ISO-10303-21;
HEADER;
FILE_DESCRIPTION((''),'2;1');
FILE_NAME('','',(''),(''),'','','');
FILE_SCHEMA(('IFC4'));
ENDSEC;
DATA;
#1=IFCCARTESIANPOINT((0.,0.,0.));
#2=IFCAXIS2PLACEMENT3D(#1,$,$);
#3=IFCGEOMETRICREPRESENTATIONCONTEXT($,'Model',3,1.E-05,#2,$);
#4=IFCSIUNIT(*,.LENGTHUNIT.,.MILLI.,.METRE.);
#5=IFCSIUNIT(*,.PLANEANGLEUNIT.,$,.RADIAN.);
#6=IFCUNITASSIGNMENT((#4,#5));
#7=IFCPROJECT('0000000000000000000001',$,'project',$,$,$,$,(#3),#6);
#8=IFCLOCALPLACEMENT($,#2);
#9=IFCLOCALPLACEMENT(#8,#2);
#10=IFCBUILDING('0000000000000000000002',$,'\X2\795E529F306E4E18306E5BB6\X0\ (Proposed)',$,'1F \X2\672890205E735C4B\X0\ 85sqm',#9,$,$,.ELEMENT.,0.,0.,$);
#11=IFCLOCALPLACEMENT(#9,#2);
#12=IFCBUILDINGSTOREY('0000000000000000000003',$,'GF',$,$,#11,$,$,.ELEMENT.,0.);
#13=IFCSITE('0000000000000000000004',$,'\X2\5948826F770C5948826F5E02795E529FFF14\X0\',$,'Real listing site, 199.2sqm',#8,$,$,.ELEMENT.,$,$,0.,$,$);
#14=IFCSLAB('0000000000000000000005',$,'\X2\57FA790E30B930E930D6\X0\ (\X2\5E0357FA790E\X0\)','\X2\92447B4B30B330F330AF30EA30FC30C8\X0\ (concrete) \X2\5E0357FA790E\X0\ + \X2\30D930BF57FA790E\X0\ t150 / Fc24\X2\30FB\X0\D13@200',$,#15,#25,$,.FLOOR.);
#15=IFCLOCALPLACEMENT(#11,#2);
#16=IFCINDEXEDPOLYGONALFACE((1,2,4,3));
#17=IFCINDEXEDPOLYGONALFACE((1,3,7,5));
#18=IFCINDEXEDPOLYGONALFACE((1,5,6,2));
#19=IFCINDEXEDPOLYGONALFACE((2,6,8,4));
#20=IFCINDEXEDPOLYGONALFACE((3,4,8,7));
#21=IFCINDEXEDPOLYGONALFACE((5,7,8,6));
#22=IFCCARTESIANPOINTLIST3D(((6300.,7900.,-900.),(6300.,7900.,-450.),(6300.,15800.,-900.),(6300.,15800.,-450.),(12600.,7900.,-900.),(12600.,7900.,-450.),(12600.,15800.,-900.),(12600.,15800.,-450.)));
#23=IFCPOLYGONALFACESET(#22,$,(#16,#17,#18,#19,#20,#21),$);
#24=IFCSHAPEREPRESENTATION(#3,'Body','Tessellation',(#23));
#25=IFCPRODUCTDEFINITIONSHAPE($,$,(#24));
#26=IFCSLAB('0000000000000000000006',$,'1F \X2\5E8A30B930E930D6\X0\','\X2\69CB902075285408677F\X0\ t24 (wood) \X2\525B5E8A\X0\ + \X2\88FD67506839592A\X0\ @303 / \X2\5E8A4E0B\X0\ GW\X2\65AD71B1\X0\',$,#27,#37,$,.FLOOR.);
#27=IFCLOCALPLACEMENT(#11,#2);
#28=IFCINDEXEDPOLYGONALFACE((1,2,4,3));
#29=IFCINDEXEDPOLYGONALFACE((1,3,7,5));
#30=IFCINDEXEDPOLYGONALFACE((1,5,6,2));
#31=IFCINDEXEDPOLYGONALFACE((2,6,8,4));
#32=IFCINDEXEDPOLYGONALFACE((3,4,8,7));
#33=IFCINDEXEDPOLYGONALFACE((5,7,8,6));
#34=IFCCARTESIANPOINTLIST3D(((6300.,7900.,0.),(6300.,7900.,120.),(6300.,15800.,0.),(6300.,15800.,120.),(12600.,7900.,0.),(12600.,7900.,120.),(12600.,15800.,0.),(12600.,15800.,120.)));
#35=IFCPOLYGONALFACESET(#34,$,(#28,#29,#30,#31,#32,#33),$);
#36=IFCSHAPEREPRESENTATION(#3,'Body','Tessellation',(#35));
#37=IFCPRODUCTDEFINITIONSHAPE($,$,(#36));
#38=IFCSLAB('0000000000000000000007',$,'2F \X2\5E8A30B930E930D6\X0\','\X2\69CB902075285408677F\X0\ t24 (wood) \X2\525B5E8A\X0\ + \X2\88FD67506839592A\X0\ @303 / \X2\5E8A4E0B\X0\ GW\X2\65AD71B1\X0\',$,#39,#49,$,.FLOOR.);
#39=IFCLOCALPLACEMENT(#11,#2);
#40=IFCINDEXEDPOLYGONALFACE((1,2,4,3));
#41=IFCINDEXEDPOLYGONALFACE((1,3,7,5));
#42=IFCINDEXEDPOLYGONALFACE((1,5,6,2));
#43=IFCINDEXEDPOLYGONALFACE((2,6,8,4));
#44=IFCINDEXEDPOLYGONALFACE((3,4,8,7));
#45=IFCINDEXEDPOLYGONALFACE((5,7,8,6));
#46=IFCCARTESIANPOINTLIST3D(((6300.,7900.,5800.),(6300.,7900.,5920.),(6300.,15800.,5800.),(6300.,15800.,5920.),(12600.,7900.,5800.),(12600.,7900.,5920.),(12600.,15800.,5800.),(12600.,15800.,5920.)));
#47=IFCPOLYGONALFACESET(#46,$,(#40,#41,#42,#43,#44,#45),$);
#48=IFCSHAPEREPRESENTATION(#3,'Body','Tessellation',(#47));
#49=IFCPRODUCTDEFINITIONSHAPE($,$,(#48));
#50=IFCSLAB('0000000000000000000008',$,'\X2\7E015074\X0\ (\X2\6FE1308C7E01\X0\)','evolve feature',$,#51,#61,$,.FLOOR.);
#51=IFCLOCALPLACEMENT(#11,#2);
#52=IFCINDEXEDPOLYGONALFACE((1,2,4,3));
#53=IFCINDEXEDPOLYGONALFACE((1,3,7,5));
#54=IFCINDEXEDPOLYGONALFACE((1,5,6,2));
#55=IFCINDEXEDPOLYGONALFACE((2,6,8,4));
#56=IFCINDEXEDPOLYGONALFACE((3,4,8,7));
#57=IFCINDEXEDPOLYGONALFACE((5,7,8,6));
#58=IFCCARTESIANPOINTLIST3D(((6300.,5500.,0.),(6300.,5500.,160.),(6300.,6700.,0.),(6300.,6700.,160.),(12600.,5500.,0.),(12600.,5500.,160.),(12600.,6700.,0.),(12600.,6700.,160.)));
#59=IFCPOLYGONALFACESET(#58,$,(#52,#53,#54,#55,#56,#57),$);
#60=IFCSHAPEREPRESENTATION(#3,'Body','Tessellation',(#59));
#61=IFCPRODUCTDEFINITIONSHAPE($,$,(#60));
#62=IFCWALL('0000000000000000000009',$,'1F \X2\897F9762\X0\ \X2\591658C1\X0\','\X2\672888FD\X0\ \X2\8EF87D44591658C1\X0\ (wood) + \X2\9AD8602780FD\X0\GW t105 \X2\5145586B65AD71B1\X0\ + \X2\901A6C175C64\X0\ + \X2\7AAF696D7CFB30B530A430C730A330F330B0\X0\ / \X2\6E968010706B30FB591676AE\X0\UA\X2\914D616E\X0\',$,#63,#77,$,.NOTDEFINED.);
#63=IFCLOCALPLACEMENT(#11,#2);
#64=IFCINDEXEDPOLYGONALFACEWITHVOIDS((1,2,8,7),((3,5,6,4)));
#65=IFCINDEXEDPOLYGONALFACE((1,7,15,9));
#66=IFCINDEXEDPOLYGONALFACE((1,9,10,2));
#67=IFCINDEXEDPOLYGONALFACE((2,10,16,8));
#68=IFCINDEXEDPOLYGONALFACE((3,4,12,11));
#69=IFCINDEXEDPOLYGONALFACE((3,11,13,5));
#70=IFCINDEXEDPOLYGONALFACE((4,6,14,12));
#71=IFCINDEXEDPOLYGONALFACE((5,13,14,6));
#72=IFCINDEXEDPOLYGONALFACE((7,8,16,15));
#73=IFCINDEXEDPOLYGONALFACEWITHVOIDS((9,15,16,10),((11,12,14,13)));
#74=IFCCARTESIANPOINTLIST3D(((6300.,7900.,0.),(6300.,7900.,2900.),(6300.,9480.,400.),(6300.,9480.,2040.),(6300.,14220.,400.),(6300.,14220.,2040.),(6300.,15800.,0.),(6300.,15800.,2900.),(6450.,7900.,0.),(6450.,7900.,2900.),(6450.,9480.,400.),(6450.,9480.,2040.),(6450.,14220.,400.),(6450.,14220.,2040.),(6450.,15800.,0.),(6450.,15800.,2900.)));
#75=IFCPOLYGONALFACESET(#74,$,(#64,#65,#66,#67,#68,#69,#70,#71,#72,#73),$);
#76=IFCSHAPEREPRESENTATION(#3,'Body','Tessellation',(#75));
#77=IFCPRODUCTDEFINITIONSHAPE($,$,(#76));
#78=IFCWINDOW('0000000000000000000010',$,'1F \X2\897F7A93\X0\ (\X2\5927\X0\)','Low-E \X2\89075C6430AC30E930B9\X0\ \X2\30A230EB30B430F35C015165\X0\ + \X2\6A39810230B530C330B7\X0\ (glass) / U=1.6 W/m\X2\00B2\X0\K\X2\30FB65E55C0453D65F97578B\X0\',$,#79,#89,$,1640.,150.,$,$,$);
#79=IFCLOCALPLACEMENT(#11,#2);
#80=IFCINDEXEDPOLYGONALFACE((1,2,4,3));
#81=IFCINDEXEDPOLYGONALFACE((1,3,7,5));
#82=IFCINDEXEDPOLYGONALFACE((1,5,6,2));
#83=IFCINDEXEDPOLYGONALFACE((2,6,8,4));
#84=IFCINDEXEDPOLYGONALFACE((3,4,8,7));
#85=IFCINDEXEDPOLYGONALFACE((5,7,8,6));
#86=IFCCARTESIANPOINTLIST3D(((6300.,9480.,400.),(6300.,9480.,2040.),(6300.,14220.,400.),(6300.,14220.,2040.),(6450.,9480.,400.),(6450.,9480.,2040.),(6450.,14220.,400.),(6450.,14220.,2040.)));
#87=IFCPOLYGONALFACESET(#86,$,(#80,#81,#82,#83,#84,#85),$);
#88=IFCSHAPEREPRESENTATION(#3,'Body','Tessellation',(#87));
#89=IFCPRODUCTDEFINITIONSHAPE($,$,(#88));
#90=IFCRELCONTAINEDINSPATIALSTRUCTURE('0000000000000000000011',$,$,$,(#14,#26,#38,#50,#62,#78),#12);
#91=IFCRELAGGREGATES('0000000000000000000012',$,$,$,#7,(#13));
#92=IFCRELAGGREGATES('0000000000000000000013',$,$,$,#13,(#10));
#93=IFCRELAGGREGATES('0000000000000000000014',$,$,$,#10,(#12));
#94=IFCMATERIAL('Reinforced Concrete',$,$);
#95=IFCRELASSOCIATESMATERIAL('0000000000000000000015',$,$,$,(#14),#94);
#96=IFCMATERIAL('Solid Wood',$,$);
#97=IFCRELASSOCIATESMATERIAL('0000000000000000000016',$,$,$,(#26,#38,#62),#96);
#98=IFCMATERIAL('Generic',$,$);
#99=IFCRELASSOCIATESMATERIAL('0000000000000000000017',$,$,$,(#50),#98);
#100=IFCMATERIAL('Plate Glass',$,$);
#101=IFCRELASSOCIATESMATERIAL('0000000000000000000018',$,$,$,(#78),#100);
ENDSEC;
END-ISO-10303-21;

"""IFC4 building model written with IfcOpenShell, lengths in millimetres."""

from ifc_helpers import new_model, si_unit, frame, frame_2d, origin, place, context, project, spatial, rectangle, extrude, material, element, fill, save


model = new_model("IFC4")

# Units and contexts
model_context = context("Model", 3, precision=1e-05, world=origin())
ifc_project = project(units=[si_unit("LENGTHUNIT", "METRE", prefix="MILLI"), si_unit("PLANEANGLEUNIT", "RADIAN")], contexts=[model_context])

# Site, building, storey
site_placement = place(None, origin())
site = spatial("IfcSite", under=ifc_project, at=site_placement, Name="奈良県奈良市神功４", ObjectType="Real listing site, 199.2sqm", CompositionType="ELEMENT", RefElevation=0.0)
building_placement = place(site_placement, origin())
building = spatial("IfcBuilding", under=site, at=building_placement, Name="神功の丘の家 (Proposed)", ObjectType="1F 木造平屋 85sqm", CompositionType="ELEMENT", ElevationOfRefHeight=0.0, ElevationOfTerrain=0.0)
storey_placement = place(building_placement, origin())
storey = spatial("IfcBuildingStorey", under=building, at=storey_placement, Name="GF", CompositionType="ELEMENT", Elevation=0.0)

# Slabs
ifc_material_1 = material(Name="Reinforced Concrete")
slab_1_placement = place(storey_placement, frame((3150.0, 3950.0, -450.0)))
element("IfcSlab", 1, at=slab_1_placement, inside=storey, material=ifc_material_1, Name="基礎スラブ (布基礎)", Description="鉄筋コンクリート (concrete) 布基礎 + ベタ基礎 t150 / Fc24・D13@200", PredefinedType="FLOOR", context=model_context, shape_type="SweptSolid", body=[
    extrude(rectangle(XDim=6300.0, YDim=7900.0, at=frame_2d((3150.0, 3950.0))), frame((3150.0, 3950.0, -450.0)), (0.0, 0.0, 1.0), 450.0),
])
ifc_material_2 = material(Name="Solid Wood")
slab_2_placement = place(storey_placement, frame((3150.0, 3950.0, 0.0)))
element("IfcSlab", 2, at=slab_2_placement, inside=storey, material=ifc_material_2, Name="1F 床スラブ", Description="構造用合板 t24 (wood) 剛床 + 製材根太 @303 / 床下 GW断熱", PredefinedType="FLOOR", context=model_context, shape_type="SweptSolid", body=[
    extrude(rectangle(XDim=6300.0, YDim=7900.0, at=frame_2d((3150.0, 3950.0))), frame((3150.0, 3950.0, 0.0)), (0.0, 0.0, 1.0), 120.0),
])
slab_3_placement = place(storey_placement, frame((3150.0, 3950.0, 2900.0)))
element("IfcSlab", 3, at=slab_3_placement, inside=storey, material=ifc_material_2, Name="2F 床スラブ", Description="構造用合板 t24 (wood) 剛床 + 製材根太 @303 / 床下 GW断熱", PredefinedType="FLOOR", context=model_context, shape_type="SweptSolid", body=[
    extrude(rectangle(XDim=6300.0, YDim=7900.0, at=frame_2d((3150.0, 3950.0))), frame((3150.0, 3950.0, 2900.0)), (0.0, 0.0, 1.0), 120.0),
])
ifc_material_3 = material(Name="Generic")
slab_4_placement = place(storey_placement, frame((3150.0, 2750.0, 0.0)))
element("IfcSlab", 4, at=slab_4_placement, inside=storey, material=ifc_material_3, Name="縁側 (濡れ縁)", Description="evolve feature", PredefinedType="FLOOR", context=model_context, shape_type="SweptSolid", body=[
    extrude(rectangle(XDim=6300.0, YDim=1200.0, at=frame_2d((3150.0, 600.0))), frame((3150.0, 2750.0, 0.0)), (0.0, 0.0, 1.0), 160.0),
])

# Shared definitions
ifc_material_4 = material(Name="Plate Glass")

# Wall, opening, window
wall_1_placement = place(storey_placement, frame((3150.0, 3950.0, 0.0)))
wall_1 = element("IfcWall", 5, at=wall_1_placement, inside=storey, material=ifc_material_2, Name="1F 西面 外壁", Description="木製 軸組外壁 (wood) + 高性能GW t105 充填断熱 + 通気層 + 窯業系サイディング / 準耐火・外皮UA配慮", PredefinedType="NOTDEFINED", context=model_context, shape_type="SweptSolid", body=[
    extrude(rectangle(XDim=150.0, YDim=7900.0, at=frame_2d((75.0, 3950.0))), frame((3150.0, 3950.0, 0.0)), (0.0, 0.0, 1.0), 2900.0),
])
opening_1_placement = place(storey_placement, frame((3150.0, 4740.0, 200.0)))
opening_1 = element("IfcOpeningElement", 6, at=opening_1_placement, cuts=wall_1, PredefinedType="NOTDEFINED", context=model_context, shape_type="SweptSolid", body=[
    extrude(rectangle(XDim=150.0, YDim=4740.0, at=frame_2d((75.0, 2370.0))), frame((3150.0, 4740.0, 200.0)), (0.0, 0.0, 1.0), 1640.0),
])
window_1_placement = place(storey_placement, frame((3150.0, 4740.0, 200.0)))
window_1 = element("IfcWindow", 7, at=window_1_placement, inside=storey, material=ifc_material_4, Name="1F 西窓 (大)", Description="Low-E 複層ガラス アルゴン封入 + 樹脂サッシ (glass) / U=1.6 W/m²K・日射取得型", OverallHeight=1640.0, OverallWidth=150.0, context=model_context, shape_type="SweptSolid", body=[
    extrude(rectangle(XDim=150.0, YDim=4740.0, at=frame_2d((75.0, 2370.0))), frame((3150.0, 4740.0, 200.0)), (0.0, 0.0, 1.0), 1640.0),
])
fill(opening_1, window_1)

save(model, "model.ifc")
